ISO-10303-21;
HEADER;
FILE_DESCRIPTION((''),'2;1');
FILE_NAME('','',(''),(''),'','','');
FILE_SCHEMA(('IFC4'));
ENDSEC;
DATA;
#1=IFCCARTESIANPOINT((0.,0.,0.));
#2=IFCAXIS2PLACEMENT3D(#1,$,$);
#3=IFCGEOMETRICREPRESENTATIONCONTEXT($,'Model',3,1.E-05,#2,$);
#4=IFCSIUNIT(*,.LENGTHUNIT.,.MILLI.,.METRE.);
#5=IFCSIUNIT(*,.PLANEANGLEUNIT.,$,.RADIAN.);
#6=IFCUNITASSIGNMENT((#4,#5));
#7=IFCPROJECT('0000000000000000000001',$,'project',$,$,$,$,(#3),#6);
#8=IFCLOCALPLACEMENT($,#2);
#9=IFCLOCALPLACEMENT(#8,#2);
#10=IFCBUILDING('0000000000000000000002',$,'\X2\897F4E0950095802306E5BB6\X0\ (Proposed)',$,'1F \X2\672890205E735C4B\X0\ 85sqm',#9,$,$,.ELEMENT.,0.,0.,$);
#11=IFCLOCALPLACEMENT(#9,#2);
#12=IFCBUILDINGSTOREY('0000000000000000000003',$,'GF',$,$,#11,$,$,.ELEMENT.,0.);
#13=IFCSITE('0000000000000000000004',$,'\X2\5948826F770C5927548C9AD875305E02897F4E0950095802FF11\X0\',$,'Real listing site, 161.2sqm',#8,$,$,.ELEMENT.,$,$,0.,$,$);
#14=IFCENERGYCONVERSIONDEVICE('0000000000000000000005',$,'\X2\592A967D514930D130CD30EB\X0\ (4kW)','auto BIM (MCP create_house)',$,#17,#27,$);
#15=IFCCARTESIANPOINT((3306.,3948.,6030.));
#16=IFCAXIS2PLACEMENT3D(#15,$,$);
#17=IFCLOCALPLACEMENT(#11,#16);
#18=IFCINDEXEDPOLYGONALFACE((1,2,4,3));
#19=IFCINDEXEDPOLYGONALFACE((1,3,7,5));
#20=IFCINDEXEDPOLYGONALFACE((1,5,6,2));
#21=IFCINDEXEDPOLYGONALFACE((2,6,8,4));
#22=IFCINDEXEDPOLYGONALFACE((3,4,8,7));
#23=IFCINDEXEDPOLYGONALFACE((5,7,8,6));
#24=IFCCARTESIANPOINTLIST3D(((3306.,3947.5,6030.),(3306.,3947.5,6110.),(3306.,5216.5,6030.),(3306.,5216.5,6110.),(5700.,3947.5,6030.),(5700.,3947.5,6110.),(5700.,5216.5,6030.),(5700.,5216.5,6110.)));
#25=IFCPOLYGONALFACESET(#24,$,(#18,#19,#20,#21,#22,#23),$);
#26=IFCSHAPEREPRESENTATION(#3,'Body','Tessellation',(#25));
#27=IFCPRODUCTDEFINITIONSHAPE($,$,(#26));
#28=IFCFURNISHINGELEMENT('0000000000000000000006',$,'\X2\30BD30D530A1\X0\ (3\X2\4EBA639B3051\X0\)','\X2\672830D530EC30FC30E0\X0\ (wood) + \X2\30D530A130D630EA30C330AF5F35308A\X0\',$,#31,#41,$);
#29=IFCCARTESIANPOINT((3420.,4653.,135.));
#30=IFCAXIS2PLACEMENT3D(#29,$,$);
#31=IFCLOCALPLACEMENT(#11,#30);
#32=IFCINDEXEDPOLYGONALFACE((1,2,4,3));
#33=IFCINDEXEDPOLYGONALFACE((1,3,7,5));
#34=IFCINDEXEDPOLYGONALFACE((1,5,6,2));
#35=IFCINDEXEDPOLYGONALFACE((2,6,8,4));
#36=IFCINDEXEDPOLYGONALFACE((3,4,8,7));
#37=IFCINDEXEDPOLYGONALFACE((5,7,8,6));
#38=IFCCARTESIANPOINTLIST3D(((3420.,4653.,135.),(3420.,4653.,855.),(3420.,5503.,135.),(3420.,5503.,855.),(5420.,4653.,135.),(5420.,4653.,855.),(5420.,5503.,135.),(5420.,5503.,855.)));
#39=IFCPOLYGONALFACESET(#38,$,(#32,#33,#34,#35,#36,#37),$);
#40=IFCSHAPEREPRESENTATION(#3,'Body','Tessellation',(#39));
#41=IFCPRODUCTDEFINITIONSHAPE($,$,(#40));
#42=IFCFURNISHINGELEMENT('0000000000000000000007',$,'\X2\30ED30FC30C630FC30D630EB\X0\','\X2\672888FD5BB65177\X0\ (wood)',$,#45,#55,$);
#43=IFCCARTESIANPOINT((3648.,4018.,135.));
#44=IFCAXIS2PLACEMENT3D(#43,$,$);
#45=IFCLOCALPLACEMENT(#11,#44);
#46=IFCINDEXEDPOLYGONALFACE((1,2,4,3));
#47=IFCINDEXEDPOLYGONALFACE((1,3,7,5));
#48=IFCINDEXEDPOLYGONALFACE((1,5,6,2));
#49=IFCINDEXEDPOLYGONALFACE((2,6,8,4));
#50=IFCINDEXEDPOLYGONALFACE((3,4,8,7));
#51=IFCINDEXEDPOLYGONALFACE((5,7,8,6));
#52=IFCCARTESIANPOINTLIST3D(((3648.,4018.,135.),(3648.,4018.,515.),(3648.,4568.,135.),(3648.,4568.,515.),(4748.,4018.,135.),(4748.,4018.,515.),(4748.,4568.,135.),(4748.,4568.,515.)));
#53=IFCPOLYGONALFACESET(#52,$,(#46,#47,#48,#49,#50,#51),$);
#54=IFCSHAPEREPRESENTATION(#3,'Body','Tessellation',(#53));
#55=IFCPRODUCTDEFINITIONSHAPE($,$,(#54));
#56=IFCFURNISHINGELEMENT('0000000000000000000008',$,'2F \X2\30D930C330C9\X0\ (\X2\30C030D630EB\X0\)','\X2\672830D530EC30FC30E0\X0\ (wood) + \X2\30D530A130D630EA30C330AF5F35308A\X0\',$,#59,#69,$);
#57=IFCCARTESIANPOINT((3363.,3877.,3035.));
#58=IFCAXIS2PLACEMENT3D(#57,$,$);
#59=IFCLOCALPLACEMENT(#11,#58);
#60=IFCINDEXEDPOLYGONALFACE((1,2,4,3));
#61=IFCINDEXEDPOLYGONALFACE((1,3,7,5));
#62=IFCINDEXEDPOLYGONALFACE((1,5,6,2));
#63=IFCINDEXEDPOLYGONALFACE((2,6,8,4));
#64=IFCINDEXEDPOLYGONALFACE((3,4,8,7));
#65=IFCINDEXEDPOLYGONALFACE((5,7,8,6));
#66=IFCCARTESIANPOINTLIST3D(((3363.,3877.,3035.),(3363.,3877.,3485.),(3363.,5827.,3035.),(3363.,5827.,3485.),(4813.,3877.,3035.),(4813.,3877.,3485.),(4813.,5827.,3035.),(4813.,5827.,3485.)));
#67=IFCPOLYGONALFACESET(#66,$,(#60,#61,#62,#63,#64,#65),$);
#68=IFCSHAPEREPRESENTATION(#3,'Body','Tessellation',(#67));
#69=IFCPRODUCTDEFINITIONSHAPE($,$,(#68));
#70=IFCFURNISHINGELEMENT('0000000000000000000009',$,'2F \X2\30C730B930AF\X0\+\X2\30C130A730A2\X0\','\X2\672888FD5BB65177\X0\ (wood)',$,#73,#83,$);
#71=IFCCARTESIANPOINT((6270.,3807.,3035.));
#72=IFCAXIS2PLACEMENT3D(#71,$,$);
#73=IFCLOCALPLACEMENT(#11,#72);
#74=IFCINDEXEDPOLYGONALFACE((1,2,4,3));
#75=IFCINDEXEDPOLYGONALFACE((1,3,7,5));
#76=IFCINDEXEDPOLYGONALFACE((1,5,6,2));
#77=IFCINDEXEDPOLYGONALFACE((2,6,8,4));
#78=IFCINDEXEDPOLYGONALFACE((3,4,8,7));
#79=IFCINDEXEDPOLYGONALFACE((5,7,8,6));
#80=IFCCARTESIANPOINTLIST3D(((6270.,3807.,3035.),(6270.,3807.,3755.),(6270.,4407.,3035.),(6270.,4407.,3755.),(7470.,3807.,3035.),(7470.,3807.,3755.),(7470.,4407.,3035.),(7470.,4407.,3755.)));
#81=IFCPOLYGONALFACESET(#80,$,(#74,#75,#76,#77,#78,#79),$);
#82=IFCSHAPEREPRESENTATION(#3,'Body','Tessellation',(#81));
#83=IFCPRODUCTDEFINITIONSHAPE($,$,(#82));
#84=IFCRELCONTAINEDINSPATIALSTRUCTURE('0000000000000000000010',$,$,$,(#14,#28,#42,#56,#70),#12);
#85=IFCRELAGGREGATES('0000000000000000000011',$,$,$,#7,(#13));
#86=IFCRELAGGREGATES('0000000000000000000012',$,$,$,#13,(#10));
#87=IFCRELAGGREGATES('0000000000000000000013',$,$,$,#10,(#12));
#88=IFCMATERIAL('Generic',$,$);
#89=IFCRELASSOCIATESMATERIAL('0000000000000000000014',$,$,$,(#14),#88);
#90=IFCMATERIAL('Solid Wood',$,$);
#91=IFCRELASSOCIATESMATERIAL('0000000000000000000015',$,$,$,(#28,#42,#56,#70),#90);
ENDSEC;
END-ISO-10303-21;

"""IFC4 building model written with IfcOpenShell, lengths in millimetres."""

from ifc_helpers import new_model, si_unit, frame, frame_2d, origin, place, context, project, spatial, rectangle, extrude, material, element, save


model = new_model("IFC4")

# Units and contexts
model_context = context("Model", 3, precision=1e-05, world=origin())
ifc_project = project(units=[si_unit("LENGTHUNIT", "METRE", prefix="MILLI"), si_unit("PLANEANGLEUNIT", "RADIAN")], contexts=[model_context])

# Site, building, storey
site_placement = place(None, origin())
site = spatial("IfcSite", under=ifc_project, at=site_placement, Name="奈良県大和高田市西三倉堂１", ObjectType="Real listing site, 161.2sqm", CompositionType="ELEMENT", RefElevation=0.0)
building_placement = place(site_placement, origin())
building = spatial("IfcBuilding", under=site, at=building_placement, Name="西三倉堂の家 (Proposed)", ObjectType="1F 木造平屋 85sqm", CompositionType="ELEMENT", ElevationOfRefHeight=0.0, ElevationOfTerrain=0.0)
storey_placement = place(building_placement, origin())
storey = spatial("IfcBuildingStorey", under=building, at=storey_placement, Name="GF", CompositionType="ELEMENT", Elevation=0.0)

# Shared definitions
ifc_material_1 = material(Name="Solid Wood")

# Shared definitions
ifc_material_2 = material(Name="Generic")

# Energy conversion device
energy_conversion_device_placement = place(storey_placement, frame((3306.0, 3948.0, 6030.0)))
element("IfcEnergyConversionDevice", 1, at=energy_conversion_device_placement, inside=storey, material=ifc_material_2, Name="太陽光パネル (4kW)", Description="auto BIM (MCP create_house)", context=model_context, shape_type="SweptSolid", body=[
    extrude(rectangle(XDim=2394.0, YDim=1269.0, at=frame_2d((1197.0, 634.0))), frame((3306.0, 3948.0, 6030.0)), (0.0, 0.0, 1.0), 80.0),
])

# Furnishing elements
furnishing_1_placement = place(storey_placement, frame((3420.0, 4653.0, 135.0)))
element("IfcFurnishingElement", 2, at=furnishing_1_placement, inside=storey, material=ifc_material_1, Name="ソファ (3人掛け)", Description="木フレーム (wood) + ファブリック張り", context=model_context, shape_type="SweptSolid", body=[
    extrude(rectangle(XDim=2000.0, YDim=850.0, at=frame_2d((1000.0, 425.0))), frame((3420.0, 4653.0, 135.0)), (0.0, 0.0, 1.0), 720.0),
])
furnishing_2_placement = place(storey_placement, frame((3648.0, 4018.0, 135.0)))
element("IfcFurnishingElement", 3, at=furnishing_2_placement, inside=storey, material=ifc_material_1, Name="ローテーブル", Description="木製家具 (wood)", context=model_context, shape_type="SweptSolid", body=[
    extrude(rectangle(XDim=1100.0, YDim=550.0, at=frame_2d((550.0, 275.0))), frame((3648.0, 4018.0, 135.0)), (0.0, 0.0, 1.0), 380.0),
])
furnishing_3_placement = place(storey_placement, frame((3363.0, 3877.0, 3035.0)))
element("IfcFurnishingElement", 4, at=furnishing_3_placement, inside=storey, material=ifc_material_1, Name="2F ベッド (ダブル)", Description="木フレーム (wood) + ファブリック張り", context=model_context, shape_type="SweptSolid", body=[
    extrude(rectangle(XDim=1450.0, YDim=1950.0, at=frame_2d((725.0, 975.0))), frame((3363.0, 3877.0, 3035.0)), (0.0, 0.0, 1.0), 450.0),
])
furnishing_4_placement = place(storey_placement, frame((6270.0, 3807.0, 3035.0)))
element("IfcFurnishingElement", 5, at=furnishing_4_placement, inside=storey, material=ifc_material_1, Name="2F デスク+チェア", Description="木製家具 (wood)", context=model_context, shape_type="SweptSolid", body=[
    extrude(rectangle(XDim=1200.0, YDim=600.0, at=frame_2d((600.0, 300.0))), frame((6270.0, 3807.0, 3035.0)), (0.0, 0.0, 1.0), 720.0),
])

save(model, "model.ifc")
